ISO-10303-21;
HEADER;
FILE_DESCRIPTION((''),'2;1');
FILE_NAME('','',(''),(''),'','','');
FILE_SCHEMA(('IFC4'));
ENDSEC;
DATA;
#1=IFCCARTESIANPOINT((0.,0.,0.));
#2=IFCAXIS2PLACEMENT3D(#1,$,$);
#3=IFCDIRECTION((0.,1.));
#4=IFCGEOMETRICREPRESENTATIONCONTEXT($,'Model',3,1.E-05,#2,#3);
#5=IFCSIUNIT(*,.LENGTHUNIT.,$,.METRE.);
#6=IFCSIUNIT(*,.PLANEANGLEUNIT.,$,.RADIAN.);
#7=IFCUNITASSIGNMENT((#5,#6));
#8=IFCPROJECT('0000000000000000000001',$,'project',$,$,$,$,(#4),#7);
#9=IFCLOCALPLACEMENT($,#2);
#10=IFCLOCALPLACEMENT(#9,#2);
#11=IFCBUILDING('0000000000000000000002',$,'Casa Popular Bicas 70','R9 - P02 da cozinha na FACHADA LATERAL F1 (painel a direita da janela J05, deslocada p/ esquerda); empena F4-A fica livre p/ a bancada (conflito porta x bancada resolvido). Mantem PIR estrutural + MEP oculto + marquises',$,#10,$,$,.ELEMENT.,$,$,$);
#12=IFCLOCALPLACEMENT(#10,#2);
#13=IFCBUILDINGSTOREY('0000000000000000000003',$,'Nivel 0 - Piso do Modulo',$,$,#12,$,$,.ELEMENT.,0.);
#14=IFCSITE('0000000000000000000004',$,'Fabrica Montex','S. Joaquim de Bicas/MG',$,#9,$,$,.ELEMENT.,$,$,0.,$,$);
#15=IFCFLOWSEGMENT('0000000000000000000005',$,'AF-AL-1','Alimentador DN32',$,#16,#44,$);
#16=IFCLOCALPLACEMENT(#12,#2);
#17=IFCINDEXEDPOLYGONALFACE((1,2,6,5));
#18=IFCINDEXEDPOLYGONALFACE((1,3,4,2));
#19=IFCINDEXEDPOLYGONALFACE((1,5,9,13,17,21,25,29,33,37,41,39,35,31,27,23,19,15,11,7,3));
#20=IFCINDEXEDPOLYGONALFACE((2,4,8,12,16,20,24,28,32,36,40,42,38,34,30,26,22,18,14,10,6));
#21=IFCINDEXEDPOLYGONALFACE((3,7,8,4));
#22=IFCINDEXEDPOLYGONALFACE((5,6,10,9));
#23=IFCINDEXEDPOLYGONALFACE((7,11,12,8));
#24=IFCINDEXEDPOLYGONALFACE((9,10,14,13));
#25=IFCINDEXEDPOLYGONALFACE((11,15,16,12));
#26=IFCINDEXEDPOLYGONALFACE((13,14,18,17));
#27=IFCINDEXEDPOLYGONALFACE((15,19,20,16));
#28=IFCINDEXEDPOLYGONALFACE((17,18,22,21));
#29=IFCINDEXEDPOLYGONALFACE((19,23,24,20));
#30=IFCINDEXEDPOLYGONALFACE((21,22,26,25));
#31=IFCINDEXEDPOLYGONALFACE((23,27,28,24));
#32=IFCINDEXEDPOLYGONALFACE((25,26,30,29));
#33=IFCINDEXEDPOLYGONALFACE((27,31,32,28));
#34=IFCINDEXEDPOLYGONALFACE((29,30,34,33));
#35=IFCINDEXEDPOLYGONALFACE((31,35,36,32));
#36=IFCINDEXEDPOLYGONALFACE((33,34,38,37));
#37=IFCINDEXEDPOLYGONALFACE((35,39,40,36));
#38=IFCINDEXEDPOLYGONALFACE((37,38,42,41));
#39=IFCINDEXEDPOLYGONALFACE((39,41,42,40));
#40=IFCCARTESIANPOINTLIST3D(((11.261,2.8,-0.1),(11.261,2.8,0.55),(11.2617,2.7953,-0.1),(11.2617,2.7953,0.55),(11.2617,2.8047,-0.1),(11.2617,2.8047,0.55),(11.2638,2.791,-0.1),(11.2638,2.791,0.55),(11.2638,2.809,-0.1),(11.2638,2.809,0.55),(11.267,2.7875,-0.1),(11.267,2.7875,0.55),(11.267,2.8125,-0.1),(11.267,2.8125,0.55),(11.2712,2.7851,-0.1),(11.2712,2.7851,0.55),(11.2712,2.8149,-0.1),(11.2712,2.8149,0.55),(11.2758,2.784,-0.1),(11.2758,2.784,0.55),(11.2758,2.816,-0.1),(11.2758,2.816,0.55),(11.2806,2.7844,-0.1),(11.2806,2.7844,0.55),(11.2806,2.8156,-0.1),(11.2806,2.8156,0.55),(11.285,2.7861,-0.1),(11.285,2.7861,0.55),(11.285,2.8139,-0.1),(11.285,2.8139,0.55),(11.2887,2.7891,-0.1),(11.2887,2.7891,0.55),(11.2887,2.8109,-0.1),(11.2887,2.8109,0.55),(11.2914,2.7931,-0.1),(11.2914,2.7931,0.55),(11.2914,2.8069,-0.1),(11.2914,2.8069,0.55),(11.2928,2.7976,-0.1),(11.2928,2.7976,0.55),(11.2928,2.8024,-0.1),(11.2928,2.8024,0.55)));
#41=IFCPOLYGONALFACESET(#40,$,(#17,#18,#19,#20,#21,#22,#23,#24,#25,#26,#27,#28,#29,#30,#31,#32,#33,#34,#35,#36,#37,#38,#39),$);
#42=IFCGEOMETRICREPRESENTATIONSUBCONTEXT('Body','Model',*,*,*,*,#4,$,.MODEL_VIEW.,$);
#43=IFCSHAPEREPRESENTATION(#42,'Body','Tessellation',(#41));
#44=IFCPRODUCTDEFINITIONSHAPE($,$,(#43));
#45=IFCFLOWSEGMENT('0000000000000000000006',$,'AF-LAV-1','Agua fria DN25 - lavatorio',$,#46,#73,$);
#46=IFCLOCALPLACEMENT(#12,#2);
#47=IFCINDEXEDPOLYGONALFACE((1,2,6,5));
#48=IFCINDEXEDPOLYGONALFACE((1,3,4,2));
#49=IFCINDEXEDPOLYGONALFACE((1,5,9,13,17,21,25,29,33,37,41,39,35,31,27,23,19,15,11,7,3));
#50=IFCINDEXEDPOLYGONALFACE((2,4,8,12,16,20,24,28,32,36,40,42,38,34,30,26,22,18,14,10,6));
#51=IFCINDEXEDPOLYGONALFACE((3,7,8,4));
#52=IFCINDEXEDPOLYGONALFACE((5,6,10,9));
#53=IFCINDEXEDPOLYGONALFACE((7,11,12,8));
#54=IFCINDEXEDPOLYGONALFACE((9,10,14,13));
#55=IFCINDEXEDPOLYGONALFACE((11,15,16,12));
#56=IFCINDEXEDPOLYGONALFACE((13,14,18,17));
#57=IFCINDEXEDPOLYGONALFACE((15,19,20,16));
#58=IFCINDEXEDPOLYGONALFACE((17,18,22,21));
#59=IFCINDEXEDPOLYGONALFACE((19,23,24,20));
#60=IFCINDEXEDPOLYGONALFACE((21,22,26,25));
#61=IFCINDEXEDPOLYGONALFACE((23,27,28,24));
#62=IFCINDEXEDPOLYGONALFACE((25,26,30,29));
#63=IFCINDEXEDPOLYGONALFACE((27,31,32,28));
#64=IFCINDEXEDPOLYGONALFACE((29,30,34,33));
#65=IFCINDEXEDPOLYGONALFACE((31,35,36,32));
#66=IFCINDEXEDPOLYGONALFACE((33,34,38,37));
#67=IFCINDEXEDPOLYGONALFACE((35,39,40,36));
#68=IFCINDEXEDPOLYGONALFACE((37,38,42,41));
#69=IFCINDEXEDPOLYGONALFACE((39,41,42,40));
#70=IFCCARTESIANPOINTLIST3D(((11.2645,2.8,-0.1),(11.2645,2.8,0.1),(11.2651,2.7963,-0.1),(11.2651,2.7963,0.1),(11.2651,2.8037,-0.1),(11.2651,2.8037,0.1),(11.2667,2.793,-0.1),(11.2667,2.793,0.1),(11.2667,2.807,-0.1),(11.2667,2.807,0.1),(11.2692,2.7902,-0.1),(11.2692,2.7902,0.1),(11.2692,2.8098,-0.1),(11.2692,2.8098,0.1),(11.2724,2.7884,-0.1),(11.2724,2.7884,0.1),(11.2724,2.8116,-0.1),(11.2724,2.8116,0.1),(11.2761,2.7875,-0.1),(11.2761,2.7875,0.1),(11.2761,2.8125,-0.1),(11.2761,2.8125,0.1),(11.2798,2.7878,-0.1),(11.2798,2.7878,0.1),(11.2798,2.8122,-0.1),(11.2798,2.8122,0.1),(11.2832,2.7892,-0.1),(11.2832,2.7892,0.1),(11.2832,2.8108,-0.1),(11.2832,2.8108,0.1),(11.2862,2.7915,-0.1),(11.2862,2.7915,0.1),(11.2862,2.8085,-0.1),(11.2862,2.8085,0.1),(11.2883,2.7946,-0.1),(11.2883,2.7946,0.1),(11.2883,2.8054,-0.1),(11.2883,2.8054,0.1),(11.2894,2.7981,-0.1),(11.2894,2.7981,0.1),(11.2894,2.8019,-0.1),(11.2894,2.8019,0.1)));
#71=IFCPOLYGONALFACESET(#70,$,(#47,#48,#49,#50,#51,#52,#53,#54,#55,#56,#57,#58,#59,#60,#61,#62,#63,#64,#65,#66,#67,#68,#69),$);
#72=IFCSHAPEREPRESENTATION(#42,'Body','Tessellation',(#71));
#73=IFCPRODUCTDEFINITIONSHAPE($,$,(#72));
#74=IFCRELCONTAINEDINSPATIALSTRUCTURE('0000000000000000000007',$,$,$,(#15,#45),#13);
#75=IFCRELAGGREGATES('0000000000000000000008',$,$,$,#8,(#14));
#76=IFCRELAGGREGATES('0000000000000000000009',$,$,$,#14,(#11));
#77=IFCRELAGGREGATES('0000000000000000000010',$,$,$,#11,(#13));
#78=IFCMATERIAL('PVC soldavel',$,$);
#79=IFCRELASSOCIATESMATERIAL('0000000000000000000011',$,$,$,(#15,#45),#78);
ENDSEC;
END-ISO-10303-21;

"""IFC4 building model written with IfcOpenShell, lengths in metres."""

from ifc_helpers import new_model, si_unit, direction, frame, origin, origin_2d, place, context, subcontext, project, spatial, circle, extrude, material, element, save


model = new_model("IFC4")

# Units and contexts
model_context = context("Model", 3, precision=1e-05, world=origin(), true_north=direction((0.0, 1.0)))
body_context = subcontext(model_context, "Body", "Model", "MODEL_VIEW")
ifc_project = project(units=[si_unit("LENGTHUNIT", "METRE"), si_unit("PLANEANGLEUNIT", "RADIAN")], contexts=[model_context])

# Site, building, storey
site_placement = place(None, origin())
site = spatial("IfcSite", under=ifc_project, at=site_placement, Name="Fabrica Montex", Description="S. Joaquim de Bicas/MG", CompositionType="ELEMENT", RefElevation=0.0)
building_placement = place(site_placement, origin())
building = spatial("IfcBuilding", under=site, at=building_placement, Name="Casa Popular Bicas 70", Description="R9 - P02 da cozinha na FACHADA LATERAL F1 (painel a direita da janela J05, deslocada p/ esquerda); empena F4-A fica livre p/ a bancada (conflito porta x bancada resolvido). Mantem PIR estrutural + MEP oculto + marquises", CompositionType="ELEMENT")
storey_placement = place(building_placement, origin())
storey = spatial("IfcBuildingStorey", under=building, at=storey_placement, Name="Nivel 0 - Piso do Modulo", CompositionType="ELEMENT", Elevation=0.0)

# Flow segments
ifc_material_1 = material(Name="PVC soldavel")
flow_segment_placement = place(None, frame((11.277, 2.8, 0.55), z_axis=(0.0, 0.0, -1.0), x_axis=(-1.0, 0.0, 0.0)))
element("IfcFlowSegment", 1, at=flow_segment_placement, inside=storey, material=ifc_material_1, Name="AF-AL-1", Description="Alimentador DN32", context=body_context, shape_type="SweptSolid", body=[
    extrude(circle(Radius=0.016, at=origin_2d()), origin(), (0.0, 0.0, 1.0), 0.65),
])
for number, where, z_axis, x_axis, name in (
    (2, (11.277, 2.8, 0.1), (0.0, 0.0, -1.0), (-1.0, 0.0, 0.0), "AF-LAV-1"),
):
    element("IfcFlowSegment", number, at=place(None, frame(where, z_axis=z_axis, x_axis=x_axis)), inside=storey, material=ifc_material_1, Name=name, Description="Agua fria DN25 - lavatorio", context=body_context, shape_type="SweptSolid", body=[
        extrude(circle(Radius=0.0125, at=origin_2d()), origin(), (0.0, 0.0, 1.0), 0.2),
    ])

save(model, "model.ifc")
